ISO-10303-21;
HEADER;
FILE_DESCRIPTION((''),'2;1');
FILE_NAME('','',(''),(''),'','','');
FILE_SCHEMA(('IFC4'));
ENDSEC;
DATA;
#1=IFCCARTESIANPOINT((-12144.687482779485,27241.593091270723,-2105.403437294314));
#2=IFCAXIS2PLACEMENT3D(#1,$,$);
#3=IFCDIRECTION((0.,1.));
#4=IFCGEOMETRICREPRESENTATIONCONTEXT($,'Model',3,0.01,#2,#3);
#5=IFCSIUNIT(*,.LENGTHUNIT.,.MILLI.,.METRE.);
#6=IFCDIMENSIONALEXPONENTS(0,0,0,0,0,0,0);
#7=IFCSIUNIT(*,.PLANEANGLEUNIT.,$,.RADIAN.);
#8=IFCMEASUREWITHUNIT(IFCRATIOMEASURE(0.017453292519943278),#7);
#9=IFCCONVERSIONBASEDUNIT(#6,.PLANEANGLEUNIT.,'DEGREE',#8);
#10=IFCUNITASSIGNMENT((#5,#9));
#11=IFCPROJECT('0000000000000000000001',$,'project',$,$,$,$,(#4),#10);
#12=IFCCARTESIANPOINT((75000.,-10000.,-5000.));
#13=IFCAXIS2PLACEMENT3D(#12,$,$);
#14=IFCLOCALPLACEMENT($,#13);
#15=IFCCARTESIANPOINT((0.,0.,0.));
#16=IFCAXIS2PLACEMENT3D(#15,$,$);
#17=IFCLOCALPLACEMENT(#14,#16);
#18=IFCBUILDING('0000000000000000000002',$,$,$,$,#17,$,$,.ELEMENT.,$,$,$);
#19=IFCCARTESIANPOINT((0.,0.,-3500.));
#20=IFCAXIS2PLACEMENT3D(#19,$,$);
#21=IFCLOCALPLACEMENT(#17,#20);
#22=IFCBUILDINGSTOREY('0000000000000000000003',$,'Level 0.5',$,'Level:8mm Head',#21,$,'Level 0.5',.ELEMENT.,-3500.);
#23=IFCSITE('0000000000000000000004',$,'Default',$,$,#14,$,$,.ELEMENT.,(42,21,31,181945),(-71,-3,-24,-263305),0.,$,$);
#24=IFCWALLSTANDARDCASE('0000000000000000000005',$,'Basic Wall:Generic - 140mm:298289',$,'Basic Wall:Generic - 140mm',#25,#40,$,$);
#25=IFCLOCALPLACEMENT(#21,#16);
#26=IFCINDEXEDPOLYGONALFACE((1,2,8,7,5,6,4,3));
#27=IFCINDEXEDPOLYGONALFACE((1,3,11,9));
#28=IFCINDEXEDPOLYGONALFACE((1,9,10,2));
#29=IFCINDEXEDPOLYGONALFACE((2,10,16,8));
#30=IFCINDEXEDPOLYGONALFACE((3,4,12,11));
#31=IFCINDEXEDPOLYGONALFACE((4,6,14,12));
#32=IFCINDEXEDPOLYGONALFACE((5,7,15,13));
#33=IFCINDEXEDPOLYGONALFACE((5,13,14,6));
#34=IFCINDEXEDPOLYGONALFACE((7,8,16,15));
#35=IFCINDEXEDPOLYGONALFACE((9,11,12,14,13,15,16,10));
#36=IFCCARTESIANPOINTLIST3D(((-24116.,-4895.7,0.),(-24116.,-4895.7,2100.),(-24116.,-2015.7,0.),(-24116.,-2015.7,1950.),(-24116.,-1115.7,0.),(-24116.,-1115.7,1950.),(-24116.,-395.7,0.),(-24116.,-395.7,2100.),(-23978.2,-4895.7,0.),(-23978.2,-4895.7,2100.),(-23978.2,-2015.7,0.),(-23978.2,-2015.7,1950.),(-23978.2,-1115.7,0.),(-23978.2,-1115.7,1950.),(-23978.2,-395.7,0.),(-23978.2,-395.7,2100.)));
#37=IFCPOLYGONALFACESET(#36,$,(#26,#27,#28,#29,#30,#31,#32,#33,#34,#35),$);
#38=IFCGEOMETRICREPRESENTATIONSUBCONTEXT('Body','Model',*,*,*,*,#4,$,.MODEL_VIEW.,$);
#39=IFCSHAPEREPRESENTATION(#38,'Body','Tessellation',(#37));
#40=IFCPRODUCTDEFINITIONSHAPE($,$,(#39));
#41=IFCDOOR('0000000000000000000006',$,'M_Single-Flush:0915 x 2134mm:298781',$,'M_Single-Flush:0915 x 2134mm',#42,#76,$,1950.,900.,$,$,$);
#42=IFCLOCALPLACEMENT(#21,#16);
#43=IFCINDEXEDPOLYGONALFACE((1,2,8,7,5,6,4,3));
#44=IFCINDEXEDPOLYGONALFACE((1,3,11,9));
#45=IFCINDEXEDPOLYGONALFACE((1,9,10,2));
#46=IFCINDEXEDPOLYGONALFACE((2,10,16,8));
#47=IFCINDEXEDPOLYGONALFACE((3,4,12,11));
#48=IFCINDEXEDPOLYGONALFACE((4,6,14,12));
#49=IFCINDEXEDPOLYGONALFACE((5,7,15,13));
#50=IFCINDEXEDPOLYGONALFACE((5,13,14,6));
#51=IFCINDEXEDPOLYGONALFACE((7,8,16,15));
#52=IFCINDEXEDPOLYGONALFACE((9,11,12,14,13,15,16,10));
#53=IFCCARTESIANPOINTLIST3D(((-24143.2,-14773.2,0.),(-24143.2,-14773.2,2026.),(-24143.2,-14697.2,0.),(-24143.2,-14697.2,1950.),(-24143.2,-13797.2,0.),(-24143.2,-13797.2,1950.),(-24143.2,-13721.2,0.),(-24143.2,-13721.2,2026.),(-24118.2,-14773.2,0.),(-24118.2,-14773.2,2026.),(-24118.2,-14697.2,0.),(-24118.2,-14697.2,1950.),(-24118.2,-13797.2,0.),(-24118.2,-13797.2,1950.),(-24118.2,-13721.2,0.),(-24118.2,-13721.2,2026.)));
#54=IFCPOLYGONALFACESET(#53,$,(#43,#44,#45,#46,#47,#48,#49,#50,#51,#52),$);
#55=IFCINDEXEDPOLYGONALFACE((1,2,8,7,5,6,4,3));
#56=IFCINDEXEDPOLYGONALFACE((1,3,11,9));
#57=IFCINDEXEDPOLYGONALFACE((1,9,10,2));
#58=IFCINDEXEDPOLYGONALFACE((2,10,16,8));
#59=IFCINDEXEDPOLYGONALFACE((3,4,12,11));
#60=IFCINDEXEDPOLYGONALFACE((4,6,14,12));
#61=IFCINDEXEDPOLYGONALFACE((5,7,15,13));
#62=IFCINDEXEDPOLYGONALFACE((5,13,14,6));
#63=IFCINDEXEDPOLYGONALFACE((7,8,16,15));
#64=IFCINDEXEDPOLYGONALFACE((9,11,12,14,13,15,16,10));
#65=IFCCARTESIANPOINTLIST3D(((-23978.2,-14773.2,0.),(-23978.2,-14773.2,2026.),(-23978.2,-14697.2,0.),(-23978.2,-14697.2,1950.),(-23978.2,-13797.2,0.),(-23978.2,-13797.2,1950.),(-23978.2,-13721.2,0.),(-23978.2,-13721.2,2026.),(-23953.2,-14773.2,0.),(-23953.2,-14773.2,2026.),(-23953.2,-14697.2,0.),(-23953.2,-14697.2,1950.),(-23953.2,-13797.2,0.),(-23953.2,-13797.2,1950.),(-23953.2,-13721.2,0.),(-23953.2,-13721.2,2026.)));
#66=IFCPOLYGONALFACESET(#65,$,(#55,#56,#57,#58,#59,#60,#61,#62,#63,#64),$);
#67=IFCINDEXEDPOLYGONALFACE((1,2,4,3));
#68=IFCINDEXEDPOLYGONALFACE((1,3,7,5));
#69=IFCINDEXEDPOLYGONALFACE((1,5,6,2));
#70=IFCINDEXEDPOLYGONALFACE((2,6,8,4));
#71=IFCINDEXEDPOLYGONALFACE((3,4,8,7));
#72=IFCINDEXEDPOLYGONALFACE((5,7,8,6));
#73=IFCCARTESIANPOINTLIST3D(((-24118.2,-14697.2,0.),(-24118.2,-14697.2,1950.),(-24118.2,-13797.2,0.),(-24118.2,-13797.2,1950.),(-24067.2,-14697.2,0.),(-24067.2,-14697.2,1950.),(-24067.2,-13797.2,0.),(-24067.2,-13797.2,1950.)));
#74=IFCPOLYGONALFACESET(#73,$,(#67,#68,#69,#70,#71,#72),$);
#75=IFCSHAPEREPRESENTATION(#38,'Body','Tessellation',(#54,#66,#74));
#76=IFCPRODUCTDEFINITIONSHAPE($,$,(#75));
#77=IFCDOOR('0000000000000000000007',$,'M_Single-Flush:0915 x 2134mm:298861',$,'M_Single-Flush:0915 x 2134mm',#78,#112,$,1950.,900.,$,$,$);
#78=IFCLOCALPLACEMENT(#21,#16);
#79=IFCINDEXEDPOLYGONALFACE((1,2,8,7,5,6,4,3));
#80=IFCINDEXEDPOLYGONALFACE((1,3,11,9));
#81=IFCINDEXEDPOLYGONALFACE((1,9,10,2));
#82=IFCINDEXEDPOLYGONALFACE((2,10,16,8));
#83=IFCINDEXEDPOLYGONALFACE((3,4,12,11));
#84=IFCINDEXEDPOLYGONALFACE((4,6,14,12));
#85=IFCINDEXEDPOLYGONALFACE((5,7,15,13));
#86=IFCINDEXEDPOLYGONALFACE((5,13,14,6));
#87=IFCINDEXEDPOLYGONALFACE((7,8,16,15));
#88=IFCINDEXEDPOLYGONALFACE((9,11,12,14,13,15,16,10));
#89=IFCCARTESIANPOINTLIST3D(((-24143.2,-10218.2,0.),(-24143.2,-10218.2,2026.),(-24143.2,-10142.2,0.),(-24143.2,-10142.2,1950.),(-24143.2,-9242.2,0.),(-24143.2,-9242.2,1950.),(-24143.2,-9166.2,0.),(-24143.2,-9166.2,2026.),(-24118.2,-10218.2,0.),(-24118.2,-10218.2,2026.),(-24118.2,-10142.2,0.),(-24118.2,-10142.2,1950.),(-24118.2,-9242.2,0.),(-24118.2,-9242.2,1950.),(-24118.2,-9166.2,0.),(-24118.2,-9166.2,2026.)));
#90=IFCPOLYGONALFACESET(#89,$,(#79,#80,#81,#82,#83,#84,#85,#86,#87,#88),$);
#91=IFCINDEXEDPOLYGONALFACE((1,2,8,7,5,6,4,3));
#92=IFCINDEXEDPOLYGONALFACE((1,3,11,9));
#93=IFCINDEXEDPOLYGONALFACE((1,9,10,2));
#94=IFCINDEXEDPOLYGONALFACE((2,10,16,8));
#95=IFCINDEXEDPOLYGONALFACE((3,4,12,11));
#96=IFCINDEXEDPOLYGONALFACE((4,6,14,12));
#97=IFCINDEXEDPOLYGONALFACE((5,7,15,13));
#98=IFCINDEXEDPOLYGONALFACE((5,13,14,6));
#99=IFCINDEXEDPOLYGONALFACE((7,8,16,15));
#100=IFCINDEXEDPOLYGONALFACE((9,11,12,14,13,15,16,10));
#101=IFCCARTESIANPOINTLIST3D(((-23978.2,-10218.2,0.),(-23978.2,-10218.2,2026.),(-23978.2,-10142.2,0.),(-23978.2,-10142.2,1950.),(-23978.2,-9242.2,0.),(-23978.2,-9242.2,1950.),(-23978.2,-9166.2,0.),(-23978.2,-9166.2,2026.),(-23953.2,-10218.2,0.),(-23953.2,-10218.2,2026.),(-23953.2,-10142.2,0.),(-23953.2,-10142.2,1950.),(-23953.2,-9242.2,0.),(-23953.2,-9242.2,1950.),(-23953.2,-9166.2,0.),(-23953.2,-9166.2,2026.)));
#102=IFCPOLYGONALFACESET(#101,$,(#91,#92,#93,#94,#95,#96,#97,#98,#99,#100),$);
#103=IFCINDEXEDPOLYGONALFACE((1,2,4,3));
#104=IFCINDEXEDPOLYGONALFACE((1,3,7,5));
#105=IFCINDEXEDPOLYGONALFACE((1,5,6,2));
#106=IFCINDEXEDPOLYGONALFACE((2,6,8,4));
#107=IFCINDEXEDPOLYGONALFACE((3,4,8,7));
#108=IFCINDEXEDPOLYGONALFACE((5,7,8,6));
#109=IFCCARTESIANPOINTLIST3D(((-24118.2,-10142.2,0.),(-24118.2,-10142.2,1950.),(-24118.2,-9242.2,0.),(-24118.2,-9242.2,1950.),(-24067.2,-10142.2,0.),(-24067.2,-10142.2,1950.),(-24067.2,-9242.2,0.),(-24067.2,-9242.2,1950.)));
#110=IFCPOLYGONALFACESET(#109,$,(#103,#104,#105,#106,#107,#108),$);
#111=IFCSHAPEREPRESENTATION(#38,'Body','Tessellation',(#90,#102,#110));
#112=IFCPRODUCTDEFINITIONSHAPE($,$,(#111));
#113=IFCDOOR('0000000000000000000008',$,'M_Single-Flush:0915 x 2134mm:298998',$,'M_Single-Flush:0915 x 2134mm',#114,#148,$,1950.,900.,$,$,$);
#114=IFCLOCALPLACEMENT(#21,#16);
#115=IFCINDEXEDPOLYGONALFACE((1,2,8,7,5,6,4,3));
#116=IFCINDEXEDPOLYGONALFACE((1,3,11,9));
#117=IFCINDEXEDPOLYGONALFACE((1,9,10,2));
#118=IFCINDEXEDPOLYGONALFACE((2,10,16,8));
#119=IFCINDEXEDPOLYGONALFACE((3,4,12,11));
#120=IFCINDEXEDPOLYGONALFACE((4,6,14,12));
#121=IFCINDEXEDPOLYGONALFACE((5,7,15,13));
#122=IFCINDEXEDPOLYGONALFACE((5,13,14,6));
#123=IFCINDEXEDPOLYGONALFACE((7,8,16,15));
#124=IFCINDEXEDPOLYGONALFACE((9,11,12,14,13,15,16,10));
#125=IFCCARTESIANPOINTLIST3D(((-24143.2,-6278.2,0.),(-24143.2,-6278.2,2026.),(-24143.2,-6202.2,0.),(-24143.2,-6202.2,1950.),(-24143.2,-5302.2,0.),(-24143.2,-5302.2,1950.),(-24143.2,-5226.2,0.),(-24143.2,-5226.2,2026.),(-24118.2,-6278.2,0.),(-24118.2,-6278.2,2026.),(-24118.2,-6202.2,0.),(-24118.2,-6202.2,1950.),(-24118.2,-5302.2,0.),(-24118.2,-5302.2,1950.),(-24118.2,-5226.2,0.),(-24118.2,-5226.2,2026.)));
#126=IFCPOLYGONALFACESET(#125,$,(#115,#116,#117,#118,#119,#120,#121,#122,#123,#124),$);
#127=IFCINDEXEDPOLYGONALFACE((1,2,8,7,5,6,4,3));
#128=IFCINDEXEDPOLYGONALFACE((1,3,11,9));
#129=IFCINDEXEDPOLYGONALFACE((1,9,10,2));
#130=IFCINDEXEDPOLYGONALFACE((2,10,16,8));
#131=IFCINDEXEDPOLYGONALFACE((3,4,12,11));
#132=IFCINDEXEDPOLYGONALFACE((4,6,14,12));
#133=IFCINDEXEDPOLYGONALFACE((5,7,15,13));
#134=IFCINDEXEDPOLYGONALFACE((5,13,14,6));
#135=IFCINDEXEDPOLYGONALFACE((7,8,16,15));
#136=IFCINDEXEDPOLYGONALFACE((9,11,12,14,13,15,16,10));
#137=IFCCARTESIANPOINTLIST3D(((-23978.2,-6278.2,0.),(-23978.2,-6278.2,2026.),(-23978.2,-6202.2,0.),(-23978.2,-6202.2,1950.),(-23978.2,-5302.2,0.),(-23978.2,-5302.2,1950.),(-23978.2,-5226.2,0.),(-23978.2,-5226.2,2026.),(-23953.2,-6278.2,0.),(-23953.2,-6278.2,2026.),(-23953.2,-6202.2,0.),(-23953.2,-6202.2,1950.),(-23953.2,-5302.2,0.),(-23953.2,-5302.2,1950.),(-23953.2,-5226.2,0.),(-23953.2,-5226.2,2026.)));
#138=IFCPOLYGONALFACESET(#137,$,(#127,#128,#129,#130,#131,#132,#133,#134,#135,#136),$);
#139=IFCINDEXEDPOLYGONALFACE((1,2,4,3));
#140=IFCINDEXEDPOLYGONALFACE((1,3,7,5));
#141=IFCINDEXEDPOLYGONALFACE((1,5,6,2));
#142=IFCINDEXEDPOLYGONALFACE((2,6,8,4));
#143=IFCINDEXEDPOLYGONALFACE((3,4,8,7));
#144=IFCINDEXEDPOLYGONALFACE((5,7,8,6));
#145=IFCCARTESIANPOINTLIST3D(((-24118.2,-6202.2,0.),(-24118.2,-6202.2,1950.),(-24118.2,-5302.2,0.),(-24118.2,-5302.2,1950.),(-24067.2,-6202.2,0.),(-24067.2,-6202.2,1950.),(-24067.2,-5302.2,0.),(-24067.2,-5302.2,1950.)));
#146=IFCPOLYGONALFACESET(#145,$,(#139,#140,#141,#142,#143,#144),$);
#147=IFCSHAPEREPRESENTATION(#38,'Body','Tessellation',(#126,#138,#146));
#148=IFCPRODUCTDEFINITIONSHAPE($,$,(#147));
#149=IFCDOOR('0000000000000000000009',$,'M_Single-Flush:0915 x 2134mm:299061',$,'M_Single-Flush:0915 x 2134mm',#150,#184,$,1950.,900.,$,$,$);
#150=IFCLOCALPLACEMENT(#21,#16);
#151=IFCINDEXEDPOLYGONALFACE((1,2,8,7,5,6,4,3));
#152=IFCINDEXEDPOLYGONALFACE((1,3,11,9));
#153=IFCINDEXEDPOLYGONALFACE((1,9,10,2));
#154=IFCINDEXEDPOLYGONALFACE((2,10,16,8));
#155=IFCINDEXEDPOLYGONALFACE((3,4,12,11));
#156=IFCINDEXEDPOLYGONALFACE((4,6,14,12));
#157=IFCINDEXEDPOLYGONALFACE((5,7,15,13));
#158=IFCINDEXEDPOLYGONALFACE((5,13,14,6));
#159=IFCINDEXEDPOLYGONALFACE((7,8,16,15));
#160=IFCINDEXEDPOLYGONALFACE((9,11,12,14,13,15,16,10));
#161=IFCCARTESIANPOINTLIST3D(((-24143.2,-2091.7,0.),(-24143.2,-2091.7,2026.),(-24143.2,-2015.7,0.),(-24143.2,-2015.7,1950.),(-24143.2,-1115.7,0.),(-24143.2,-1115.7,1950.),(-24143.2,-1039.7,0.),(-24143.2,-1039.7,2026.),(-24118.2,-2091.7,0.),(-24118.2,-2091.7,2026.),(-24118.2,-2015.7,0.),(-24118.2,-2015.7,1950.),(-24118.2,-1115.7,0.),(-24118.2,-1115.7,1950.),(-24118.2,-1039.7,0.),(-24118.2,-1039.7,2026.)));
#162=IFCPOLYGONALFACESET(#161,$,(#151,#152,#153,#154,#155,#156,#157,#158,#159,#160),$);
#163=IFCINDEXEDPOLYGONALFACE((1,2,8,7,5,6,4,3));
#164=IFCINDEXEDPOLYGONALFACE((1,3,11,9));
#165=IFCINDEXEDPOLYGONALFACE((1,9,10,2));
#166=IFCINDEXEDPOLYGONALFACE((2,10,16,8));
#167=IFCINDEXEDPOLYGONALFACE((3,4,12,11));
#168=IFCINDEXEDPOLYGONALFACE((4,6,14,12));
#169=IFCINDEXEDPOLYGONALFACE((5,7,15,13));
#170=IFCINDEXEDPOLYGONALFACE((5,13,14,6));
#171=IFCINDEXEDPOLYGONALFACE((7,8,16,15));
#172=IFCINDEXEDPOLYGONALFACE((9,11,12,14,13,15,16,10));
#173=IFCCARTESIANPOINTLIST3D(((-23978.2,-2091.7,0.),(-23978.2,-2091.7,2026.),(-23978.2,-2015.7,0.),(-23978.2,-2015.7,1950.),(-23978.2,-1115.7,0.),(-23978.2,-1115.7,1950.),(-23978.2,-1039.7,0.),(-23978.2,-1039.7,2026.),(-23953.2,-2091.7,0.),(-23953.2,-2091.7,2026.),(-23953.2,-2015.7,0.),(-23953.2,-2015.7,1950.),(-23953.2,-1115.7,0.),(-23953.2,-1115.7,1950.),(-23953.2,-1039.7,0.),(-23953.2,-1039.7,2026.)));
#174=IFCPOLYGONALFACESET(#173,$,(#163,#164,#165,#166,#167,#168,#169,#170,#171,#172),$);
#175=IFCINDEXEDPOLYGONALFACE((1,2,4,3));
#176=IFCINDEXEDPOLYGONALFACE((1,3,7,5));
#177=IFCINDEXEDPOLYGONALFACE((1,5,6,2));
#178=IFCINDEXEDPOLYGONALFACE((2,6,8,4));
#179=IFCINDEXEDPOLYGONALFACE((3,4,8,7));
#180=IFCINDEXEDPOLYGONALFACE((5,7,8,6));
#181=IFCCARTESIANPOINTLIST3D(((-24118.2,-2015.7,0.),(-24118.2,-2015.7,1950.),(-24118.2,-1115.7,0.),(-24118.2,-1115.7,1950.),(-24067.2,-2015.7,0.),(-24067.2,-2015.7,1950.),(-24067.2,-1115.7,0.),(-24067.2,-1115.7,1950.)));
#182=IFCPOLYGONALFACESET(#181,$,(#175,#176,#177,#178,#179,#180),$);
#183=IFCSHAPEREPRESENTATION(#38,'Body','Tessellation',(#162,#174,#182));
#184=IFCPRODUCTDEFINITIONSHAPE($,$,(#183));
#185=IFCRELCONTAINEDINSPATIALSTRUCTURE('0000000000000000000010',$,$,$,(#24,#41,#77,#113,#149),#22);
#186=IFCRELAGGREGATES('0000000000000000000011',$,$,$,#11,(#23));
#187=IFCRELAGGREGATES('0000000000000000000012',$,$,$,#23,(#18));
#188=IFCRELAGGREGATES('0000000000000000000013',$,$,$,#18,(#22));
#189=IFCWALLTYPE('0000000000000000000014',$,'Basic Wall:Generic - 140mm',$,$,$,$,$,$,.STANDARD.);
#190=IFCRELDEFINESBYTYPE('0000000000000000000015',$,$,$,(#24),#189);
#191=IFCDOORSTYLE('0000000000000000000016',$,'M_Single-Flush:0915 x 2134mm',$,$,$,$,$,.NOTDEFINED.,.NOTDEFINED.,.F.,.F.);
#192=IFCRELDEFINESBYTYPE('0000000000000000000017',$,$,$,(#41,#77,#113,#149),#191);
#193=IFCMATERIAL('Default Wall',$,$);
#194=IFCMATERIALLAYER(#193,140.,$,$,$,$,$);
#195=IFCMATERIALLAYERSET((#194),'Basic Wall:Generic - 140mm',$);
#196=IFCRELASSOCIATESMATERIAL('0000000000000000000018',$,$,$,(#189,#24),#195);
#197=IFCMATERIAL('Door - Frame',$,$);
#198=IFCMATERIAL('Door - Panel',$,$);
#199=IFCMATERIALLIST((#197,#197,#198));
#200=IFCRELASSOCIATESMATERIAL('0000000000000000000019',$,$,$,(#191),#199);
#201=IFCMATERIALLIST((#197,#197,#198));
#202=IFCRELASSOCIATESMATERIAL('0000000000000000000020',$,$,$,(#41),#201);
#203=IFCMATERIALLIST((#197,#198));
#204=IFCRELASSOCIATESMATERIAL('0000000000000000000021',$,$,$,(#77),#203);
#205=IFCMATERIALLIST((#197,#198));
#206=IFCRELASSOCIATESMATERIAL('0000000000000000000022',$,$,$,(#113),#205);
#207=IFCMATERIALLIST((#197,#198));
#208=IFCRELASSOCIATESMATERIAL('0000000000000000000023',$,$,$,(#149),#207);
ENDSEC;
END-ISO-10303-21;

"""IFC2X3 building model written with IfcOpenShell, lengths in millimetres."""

from ifc_helpers import new_model, entity, si_unit, converted_unit, direction, frame, frame_2d, origin, place, context, subcontext, project, spatial, polyline, rectangle, outline, extrude, clip, bounded_halfspace, source, transform, mapped, material, material_list, layer, layer_set, layer_usage, type_object, type_shapes, element, fill, save


model = new_model("IFC2X3")

# Units and contexts
model_context = context("Model", 3, precision=0.01, world=frame((-12144.687482779485, 27241.593091270723, -2105.403437294314)), true_north=direction((0.0, 1.0)))
body_context = subcontext(model_context, "Body", "Model", "MODEL_VIEW")
ifc_project = project(units=[si_unit("LENGTHUNIT", "METRE", prefix="MILLI"), converted_unit("PLANEANGLEUNIT", "DEGREE", entity("IfcRatioMeasure", 0.017453292519943278), si_unit("PLANEANGLEUNIT", "RADIAN"), dimensions=[0, 0, 0, 0, 0, 0, 0])], contexts=[model_context])

# Site, building, storey
site_placement = place(None, frame((75000.0, -10000.0, -5000.0)))
site = spatial("IfcSite", under=ifc_project, at=site_placement, Name="Default", CompositionType="ELEMENT", RefLatitude=(42, 21, 31, 181945), RefLongitude=(-71, -3, -24, -263305), RefElevation=0.0)
building_placement = place(site_placement, origin())
building = spatial("IfcBuilding", under=site, at=building_placement, CompositionType="ELEMENT")
storey_placement = place(building_placement, frame((0.0, 0.0, -3500.0)))
storey = spatial("IfcBuildingStorey", under=building, at=storey_placement, Name="Level 0.5", ObjectType="Level:8mm Head", LongName="Level 0.5", CompositionType="ELEMENT", Elevation=-3500.0)

# Shared definitions
ifc_material_1 = material(Name="Default Wall")

# Shared definitions
ifc_material_2 = material(Name="Door - Frame")
ifc_material_3 = material(Name="Door - Panel")

# Wall, openings, doors
ifc_layer_1 = layer(ifc_material_1, 140.0)
ifc_layer_set_1 = layer_set([ifc_layer_1], Name="Basic Wall:Generic - 140mm")
ifc_layer_usage_1 = layer_usage(ifc_layer_set_1, "AXIS2", "NEGATIVE", 70.0)
wall_type_1 = type_object("IfcWallType", Name="Basic Wall:Generic - 140mm", PredefinedType="STANDARD", material=ifc_layer_set_1)
wall_1_placement = place(storey_placement, frame((-24048.2, -395.7, 0.0), z_axis=(0.0, 0.0, 1.0), x_axis=(0.0, -1.0, 0.0)))
wall_1 = element("IfcWallStandardCase", 1, at=wall_1_placement, inside=storey, type_object=wall_type_1, material=ifc_layer_usage_1, Name="Basic Wall:Generic - 140mm:298289", ObjectType="Basic Wall:Generic - 140mm", context=body_context, shape_type="Clipping", body=[
    clip(extrude(rectangle(XDim=137.7, YDim=4500.0, at=frame_2d((2250.0, 1.1), x_axis=(0.0, 1.0))), origin(), (0.0, 0.0, 1.0), 2100.0), bounded_halfspace(frame((4500.0, -67.7, 2100.0), z_axis=(0.0, 0.0, -1.0), x_axis=(0.0, -1.0, 0.0)), True, frame((4500.0, -67.7, 2100.0)), polyline([(0.0, 0.0), (0.0, 41986.2), (-1371600.0, 41986.2), (-1371600.0, 0.0), (0.0, 0.0)]))),
])
opening_1_placement = place(wall_1_placement, frame((14301.5, 70.0, 0.0)))
opening_1 = element("IfcOpeningElement", 2, at=opening_1_placement, cuts=wall_1, ObjectType="Opening", context=body_context, shape_type="SweptSolid", body=[
    extrude(rectangle(XDim=900.0, YDim=1950.0, at=frame_2d((975.0, 450.0), x_axis=(0.0, -1.0))), frame((0.0, 0.0, 0.0), z_axis=(0.0, -1.0, 0.0), x_axis=(0.0, 0.0, 1.0)), (0.0, 0.0, 1.0), 140.0),
])
opening_2_placement = place(wall_1_placement, frame((9746.5, 70.0, 0.0)))
opening_2 = element("IfcOpeningElement", 3, at=opening_2_placement, cuts=wall_1, ObjectType="Opening", context=body_context, shape_type="SweptSolid", body=[
    extrude(rectangle(XDim=900.0, YDim=1950.0, at=frame_2d((975.0, 450.0), x_axis=(0.0, -1.0))), frame((0.0, 0.0, 0.0), z_axis=(0.0, -1.0, 0.0), x_axis=(0.0, 0.0, 1.0)), (0.0, 0.0, 1.0), 140.0),
])
opening_3_placement = place(wall_1_placement, frame((5806.5, 70.0, 0.0)))
opening_3 = element("IfcOpeningElement", 4, at=opening_3_placement, cuts=wall_1, ObjectType="Opening", context=body_context, shape_type="SweptSolid", body=[
    extrude(rectangle(XDim=900.0, YDim=1950.0, at=frame_2d((975.0, 450.0), x_axis=(0.0, -1.0))), frame((0.0, 0.0, 0.0), z_axis=(0.0, -1.0, 0.0), x_axis=(0.0, 0.0, 1.0)), (0.0, 0.0, 1.0), 140.0),
])
opening_4_placement = place(wall_1_placement, frame((1620.0, 70.0, 0.0)))
opening_4 = element("IfcOpeningElement", 5, at=opening_4_placement, cuts=wall_1, ObjectType="Opening", context=body_context, shape_type="SweptSolid", body=[
    extrude(rectangle(XDim=900.0, YDim=1950.0, at=frame_2d((975.0, 450.0), x_axis=(0.0, -1.0))), frame((0.0, 0.0, 0.0), z_axis=(0.0, -1.0, 0.0), x_axis=(0.0, 0.0, 1.0)), (0.0, 0.0, 1.0), 140.0),
])
ifc_material_list_1 = material_list([ifc_material_2, ifc_material_2, ifc_material_3])
ifc_material_list_2 = material_list([ifc_material_2, ifc_material_2, ifc_material_3])
door_style_1 = type_object("IfcDoorStyle", Name="M_Single-Flush:0915 x 2134mm", ConstructionType="NOTDEFINED", OperationType="NOTDEFINED", ParameterTakesPrecedence=False, Sizeable=False, material=ifc_material_list_2)
shared_shape_1 = source(origin(), body_context, "Body", "SweptSolid", [
    extrude(outline(polyline([(-526.0, -1032.0), (526.0, -1032.0), (526.0, 994.0), (450.0, 994.0), (450.0, -956.0), (-450.0, -956.0), (-450.0, 994.0), (-526.0, 994.0), (-526.0, -1032.0)])), frame((450.0, 165.0, 994.0), z_axis=(0.0, -1.0, 0.0), x_axis=(-1.0, 0.0, 0.0)), (0.0, 0.0, 1.0), 25.0),
    extrude(outline(polyline([(-1032.0, -526.0), (994.0, -526.0), (994.0, -450.0), (-956.0, -450.0), (-956.0, 450.0), (994.0, 450.0), (994.0, 526.0), (-1032.0, 526.0), (-1032.0, -526.0)])), frame((450.0, 0.0, 994.0), z_axis=(0.0, -1.0, 0.0), x_axis=(0.0, 0.0, -1.0)), (0.0, 0.0, 1.0), 25.0),
    extrude(rectangle(XDim=900.0, YDim=51.0, at=frame_2d((0.0, 0.0), x_axis=(1.0, 0.0))), frame((450.0, 114.5, 0.0)), (0.0, 0.0, 1.0), 1950.0),
])
type_shapes(door_style_1, [shared_shape_1])
door_1_placement = place(opening_1_placement, frame((0.0, 0.0, 0.0), z_axis=(0.0, 0.0, 1.0), x_axis=(-1.0, 0.0, 0.0)))
door_1 = element("IfcDoor", 6, at=door_1_placement, inside=storey, type_object=door_style_1, material=ifc_material_list_1, Name="M_Single-Flush:0915 x 2134mm:298781", ObjectType="M_Single-Flush:0915 x 2134mm", OverallHeight=1950.0, OverallWidth=900.0, context=body_context, shape_type="MappedRepresentation", body=[
    mapped(shared_shape_1, transform((0.0, 0.0, 0.0), scale=1.0)),
])
fill(opening_1, door_1)
ifc_material_list_3 = material_list([ifc_material_2, ifc_material_3])
door_2_placement = place(opening_2_placement, frame((0.0, 0.0, 0.0), z_axis=(0.0, 0.0, 1.0), x_axis=(-1.0, 0.0, 0.0)))
door_2 = element("IfcDoor", 7, at=door_2_placement, inside=storey, type_object=door_style_1, material=ifc_material_list_3, Name="M_Single-Flush:0915 x 2134mm:298861", ObjectType="M_Single-Flush:0915 x 2134mm", OverallHeight=1950.0, OverallWidth=900.0, context=body_context, shape_type="MappedRepresentation", body=[
    mapped(shared_shape_1, transform((0.0, 0.0, 0.0), scale=1.0)),
])
fill(opening_2, door_2)
ifc_material_list_4 = material_list([ifc_material_2, ifc_material_3])
door_3_placement = place(opening_3_placement, frame((0.0, 0.0, 0.0), z_axis=(0.0, 0.0, 1.0), x_axis=(-1.0, 0.0, 0.0)))
door_3 = element("IfcDoor", 8, at=door_3_placement, inside=storey, type_object=door_style_1, material=ifc_material_list_4, Name="M_Single-Flush:0915 x 2134mm:298998", ObjectType="M_Single-Flush:0915 x 2134mm", OverallHeight=1950.0, OverallWidth=900.0, context=body_context, shape_type="MappedRepresentation", body=[
    mapped(shared_shape_1, transform((0.0, 0.0, 0.0), scale=1.0)),
])
fill(opening_3, door_3)
ifc_material_list_5 = material_list([ifc_material_2, ifc_material_3])
door_4_placement = place(opening_4_placement, frame((0.0, 0.0, 0.0), z_axis=(0.0, 0.0, 1.0), x_axis=(-1.0, 0.0, 0.0)))
door_4 = element("IfcDoor", 9, at=door_4_placement, inside=storey, type_object=door_style_1, material=ifc_material_list_5, Name="M_Single-Flush:0915 x 2134mm:299061", ObjectType="M_Single-Flush:0915 x 2134mm", OverallHeight=1950.0, OverallWidth=900.0, context=body_context, shape_type="MappedRepresentation", body=[
    mapped(shared_shape_1, transform((0.0, 0.0, 0.0), scale=1.0)),
])
fill(opening_4, door_4)

save(model, "model.ifc")
